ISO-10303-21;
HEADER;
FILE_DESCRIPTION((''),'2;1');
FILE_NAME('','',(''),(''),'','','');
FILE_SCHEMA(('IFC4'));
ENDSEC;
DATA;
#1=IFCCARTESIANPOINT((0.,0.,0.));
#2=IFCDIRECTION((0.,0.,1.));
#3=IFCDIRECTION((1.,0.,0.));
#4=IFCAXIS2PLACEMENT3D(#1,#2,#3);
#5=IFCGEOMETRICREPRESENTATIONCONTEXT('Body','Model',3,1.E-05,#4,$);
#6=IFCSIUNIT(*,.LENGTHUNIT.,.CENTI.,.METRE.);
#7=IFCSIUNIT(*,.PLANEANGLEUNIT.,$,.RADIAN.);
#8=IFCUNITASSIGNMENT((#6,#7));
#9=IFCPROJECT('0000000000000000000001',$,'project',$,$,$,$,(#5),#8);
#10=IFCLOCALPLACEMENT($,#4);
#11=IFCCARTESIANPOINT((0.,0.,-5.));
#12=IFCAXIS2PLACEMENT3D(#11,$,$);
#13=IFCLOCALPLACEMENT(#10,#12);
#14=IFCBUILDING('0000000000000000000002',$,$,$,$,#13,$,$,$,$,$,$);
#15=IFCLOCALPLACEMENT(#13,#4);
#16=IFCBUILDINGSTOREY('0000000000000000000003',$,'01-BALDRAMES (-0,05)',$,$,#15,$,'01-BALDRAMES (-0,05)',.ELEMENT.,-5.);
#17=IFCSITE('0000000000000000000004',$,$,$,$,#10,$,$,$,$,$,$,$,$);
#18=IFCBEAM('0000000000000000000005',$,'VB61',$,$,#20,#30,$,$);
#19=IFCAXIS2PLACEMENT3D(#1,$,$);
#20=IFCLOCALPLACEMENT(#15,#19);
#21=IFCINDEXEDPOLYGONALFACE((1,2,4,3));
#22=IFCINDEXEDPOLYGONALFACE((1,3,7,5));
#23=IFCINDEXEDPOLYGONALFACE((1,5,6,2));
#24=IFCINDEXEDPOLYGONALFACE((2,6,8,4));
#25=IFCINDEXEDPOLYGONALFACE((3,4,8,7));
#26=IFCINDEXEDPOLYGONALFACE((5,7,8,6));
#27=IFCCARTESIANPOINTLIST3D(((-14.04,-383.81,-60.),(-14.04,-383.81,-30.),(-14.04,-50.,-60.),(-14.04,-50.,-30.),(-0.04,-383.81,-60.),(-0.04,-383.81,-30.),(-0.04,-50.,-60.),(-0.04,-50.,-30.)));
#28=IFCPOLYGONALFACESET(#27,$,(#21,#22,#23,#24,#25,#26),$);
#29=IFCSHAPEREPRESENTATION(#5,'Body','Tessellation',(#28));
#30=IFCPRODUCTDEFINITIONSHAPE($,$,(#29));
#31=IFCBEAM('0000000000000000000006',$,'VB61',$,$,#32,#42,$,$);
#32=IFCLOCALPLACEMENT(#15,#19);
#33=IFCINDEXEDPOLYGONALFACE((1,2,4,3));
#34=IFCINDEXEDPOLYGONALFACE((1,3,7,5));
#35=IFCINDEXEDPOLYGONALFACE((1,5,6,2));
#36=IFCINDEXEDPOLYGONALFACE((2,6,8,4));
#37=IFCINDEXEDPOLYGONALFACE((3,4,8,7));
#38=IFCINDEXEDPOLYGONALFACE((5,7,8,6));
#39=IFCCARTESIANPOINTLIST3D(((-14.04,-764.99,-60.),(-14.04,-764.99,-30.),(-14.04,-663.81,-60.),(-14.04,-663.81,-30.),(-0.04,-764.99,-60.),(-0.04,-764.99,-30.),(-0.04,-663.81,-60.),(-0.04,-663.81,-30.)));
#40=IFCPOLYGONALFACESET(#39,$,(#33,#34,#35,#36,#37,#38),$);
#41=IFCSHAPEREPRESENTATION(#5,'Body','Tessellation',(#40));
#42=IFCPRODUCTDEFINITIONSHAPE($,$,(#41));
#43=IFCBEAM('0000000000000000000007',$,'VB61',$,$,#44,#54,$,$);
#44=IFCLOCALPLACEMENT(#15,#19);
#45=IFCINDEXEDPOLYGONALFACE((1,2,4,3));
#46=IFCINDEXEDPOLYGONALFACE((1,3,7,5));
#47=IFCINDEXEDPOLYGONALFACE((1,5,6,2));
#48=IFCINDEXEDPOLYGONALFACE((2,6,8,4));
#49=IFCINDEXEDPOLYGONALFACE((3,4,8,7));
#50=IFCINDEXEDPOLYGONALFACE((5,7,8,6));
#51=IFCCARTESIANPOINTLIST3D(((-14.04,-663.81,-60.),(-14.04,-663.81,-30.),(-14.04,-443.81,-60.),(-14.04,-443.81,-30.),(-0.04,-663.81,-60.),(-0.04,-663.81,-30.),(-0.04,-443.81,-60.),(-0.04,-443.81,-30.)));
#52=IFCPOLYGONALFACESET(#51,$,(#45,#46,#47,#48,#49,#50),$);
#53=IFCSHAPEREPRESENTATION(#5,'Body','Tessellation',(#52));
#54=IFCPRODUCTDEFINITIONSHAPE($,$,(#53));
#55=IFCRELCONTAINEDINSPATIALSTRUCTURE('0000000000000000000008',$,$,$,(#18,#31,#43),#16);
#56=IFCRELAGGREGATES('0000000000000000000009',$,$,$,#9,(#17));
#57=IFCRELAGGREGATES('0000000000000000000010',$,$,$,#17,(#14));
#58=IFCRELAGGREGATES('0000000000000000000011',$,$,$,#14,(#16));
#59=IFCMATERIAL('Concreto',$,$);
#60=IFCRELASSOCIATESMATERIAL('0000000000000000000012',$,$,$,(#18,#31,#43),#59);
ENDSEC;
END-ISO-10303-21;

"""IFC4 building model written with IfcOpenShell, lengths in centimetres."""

from ifc_helpers import new_model, si_unit, frame, origin_with_axes, origin_2d_with_axis, place, context, project, spatial, rectangle, extrude, material, element, save


model = new_model("IFC4")

# Units and contexts
model_context = context("Model", 3, precision=1e-05, world=origin_with_axes(), identifier="Body")
ifc_project = project(units=[si_unit("LENGTHUNIT", "METRE", prefix="CENTI"), si_unit("PLANEANGLEUNIT", "RADIAN")], contexts=[model_context])

# Site, building, storey
site_placement = place(None, origin_with_axes())
site = spatial("IfcSite", under=ifc_project, at=site_placement)
building_placement = place(site_placement, frame((0.0, 0.0, -5.0)))
building = spatial("IfcBuilding", under=site, at=building_placement)
storey_placement = place(building_placement, origin_with_axes())
storey = spatial("IfcBuildingStorey", under=building, at=storey_placement, Name="01-BALDRAMES (-0,05)", LongName="01-BALDRAMES (-0,05)", CompositionType="ELEMENT", Elevation=-5.0)

# Shared definitions
ifc_material = material(Name="Concreto")

# Beams
beam_1_placement = place(storey_placement, frame((-7.04, -216.91, -30.0), z_axis=(0.0, 0.0, 1.0), x_axis=(1.0, 0.0, 0.0)))
element("IfcBeam", 1, at=beam_1_placement, inside=storey, material=ifc_material, Name="VB61", context=model_context, shape_type="SolidModel", body=[
    extrude(rectangle(XDim=14.0, YDim=30.0, at=origin_2d_with_axis()), frame((0.0, -166.91, -15.0), z_axis=(0.0, 1.0, 0.0), x_axis=(1.0, 0.0, 0.0)), (0.0, 0.0, 1.0), 333.81),
])
beam_2_placement = place(storey_placement, frame((-7.04, -714.4, -30.0), z_axis=(0.0, 0.0, 1.0), x_axis=(1.0, 0.0, 0.0)))
element("IfcBeam", 2, at=beam_2_placement, inside=storey, material=ifc_material, Name="VB61", context=model_context, shape_type="SolidModel", body=[
    extrude(rectangle(XDim=14.0, YDim=30.0, at=origin_2d_with_axis()), frame((0.0, -50.59, -15.0), z_axis=(0.0, 1.0, 0.0), x_axis=(1.0, 0.0, 0.0)), (0.0, 0.0, 1.0), 101.18),
])
beam_3_placement = place(storey_placement, frame((-7.04, -553.81, -30.0), z_axis=(0.0, 0.0, 1.0), x_axis=(1.0, 0.0, 0.0)))
element("IfcBeam", 3, at=beam_3_placement, inside=storey, material=ifc_material, Name="VB61", context=model_context, shape_type="SolidModel", body=[
    extrude(rectangle(XDim=14.0, YDim=30.0, at=origin_2d_with_axis()), frame((0.0, -110.0, -15.0), z_axis=(0.0, 1.0, 0.0), x_axis=(1.0, 0.0, 0.0)), (0.0, 0.0, 1.0), 220.0),
])

save(model, "model.ifc")
